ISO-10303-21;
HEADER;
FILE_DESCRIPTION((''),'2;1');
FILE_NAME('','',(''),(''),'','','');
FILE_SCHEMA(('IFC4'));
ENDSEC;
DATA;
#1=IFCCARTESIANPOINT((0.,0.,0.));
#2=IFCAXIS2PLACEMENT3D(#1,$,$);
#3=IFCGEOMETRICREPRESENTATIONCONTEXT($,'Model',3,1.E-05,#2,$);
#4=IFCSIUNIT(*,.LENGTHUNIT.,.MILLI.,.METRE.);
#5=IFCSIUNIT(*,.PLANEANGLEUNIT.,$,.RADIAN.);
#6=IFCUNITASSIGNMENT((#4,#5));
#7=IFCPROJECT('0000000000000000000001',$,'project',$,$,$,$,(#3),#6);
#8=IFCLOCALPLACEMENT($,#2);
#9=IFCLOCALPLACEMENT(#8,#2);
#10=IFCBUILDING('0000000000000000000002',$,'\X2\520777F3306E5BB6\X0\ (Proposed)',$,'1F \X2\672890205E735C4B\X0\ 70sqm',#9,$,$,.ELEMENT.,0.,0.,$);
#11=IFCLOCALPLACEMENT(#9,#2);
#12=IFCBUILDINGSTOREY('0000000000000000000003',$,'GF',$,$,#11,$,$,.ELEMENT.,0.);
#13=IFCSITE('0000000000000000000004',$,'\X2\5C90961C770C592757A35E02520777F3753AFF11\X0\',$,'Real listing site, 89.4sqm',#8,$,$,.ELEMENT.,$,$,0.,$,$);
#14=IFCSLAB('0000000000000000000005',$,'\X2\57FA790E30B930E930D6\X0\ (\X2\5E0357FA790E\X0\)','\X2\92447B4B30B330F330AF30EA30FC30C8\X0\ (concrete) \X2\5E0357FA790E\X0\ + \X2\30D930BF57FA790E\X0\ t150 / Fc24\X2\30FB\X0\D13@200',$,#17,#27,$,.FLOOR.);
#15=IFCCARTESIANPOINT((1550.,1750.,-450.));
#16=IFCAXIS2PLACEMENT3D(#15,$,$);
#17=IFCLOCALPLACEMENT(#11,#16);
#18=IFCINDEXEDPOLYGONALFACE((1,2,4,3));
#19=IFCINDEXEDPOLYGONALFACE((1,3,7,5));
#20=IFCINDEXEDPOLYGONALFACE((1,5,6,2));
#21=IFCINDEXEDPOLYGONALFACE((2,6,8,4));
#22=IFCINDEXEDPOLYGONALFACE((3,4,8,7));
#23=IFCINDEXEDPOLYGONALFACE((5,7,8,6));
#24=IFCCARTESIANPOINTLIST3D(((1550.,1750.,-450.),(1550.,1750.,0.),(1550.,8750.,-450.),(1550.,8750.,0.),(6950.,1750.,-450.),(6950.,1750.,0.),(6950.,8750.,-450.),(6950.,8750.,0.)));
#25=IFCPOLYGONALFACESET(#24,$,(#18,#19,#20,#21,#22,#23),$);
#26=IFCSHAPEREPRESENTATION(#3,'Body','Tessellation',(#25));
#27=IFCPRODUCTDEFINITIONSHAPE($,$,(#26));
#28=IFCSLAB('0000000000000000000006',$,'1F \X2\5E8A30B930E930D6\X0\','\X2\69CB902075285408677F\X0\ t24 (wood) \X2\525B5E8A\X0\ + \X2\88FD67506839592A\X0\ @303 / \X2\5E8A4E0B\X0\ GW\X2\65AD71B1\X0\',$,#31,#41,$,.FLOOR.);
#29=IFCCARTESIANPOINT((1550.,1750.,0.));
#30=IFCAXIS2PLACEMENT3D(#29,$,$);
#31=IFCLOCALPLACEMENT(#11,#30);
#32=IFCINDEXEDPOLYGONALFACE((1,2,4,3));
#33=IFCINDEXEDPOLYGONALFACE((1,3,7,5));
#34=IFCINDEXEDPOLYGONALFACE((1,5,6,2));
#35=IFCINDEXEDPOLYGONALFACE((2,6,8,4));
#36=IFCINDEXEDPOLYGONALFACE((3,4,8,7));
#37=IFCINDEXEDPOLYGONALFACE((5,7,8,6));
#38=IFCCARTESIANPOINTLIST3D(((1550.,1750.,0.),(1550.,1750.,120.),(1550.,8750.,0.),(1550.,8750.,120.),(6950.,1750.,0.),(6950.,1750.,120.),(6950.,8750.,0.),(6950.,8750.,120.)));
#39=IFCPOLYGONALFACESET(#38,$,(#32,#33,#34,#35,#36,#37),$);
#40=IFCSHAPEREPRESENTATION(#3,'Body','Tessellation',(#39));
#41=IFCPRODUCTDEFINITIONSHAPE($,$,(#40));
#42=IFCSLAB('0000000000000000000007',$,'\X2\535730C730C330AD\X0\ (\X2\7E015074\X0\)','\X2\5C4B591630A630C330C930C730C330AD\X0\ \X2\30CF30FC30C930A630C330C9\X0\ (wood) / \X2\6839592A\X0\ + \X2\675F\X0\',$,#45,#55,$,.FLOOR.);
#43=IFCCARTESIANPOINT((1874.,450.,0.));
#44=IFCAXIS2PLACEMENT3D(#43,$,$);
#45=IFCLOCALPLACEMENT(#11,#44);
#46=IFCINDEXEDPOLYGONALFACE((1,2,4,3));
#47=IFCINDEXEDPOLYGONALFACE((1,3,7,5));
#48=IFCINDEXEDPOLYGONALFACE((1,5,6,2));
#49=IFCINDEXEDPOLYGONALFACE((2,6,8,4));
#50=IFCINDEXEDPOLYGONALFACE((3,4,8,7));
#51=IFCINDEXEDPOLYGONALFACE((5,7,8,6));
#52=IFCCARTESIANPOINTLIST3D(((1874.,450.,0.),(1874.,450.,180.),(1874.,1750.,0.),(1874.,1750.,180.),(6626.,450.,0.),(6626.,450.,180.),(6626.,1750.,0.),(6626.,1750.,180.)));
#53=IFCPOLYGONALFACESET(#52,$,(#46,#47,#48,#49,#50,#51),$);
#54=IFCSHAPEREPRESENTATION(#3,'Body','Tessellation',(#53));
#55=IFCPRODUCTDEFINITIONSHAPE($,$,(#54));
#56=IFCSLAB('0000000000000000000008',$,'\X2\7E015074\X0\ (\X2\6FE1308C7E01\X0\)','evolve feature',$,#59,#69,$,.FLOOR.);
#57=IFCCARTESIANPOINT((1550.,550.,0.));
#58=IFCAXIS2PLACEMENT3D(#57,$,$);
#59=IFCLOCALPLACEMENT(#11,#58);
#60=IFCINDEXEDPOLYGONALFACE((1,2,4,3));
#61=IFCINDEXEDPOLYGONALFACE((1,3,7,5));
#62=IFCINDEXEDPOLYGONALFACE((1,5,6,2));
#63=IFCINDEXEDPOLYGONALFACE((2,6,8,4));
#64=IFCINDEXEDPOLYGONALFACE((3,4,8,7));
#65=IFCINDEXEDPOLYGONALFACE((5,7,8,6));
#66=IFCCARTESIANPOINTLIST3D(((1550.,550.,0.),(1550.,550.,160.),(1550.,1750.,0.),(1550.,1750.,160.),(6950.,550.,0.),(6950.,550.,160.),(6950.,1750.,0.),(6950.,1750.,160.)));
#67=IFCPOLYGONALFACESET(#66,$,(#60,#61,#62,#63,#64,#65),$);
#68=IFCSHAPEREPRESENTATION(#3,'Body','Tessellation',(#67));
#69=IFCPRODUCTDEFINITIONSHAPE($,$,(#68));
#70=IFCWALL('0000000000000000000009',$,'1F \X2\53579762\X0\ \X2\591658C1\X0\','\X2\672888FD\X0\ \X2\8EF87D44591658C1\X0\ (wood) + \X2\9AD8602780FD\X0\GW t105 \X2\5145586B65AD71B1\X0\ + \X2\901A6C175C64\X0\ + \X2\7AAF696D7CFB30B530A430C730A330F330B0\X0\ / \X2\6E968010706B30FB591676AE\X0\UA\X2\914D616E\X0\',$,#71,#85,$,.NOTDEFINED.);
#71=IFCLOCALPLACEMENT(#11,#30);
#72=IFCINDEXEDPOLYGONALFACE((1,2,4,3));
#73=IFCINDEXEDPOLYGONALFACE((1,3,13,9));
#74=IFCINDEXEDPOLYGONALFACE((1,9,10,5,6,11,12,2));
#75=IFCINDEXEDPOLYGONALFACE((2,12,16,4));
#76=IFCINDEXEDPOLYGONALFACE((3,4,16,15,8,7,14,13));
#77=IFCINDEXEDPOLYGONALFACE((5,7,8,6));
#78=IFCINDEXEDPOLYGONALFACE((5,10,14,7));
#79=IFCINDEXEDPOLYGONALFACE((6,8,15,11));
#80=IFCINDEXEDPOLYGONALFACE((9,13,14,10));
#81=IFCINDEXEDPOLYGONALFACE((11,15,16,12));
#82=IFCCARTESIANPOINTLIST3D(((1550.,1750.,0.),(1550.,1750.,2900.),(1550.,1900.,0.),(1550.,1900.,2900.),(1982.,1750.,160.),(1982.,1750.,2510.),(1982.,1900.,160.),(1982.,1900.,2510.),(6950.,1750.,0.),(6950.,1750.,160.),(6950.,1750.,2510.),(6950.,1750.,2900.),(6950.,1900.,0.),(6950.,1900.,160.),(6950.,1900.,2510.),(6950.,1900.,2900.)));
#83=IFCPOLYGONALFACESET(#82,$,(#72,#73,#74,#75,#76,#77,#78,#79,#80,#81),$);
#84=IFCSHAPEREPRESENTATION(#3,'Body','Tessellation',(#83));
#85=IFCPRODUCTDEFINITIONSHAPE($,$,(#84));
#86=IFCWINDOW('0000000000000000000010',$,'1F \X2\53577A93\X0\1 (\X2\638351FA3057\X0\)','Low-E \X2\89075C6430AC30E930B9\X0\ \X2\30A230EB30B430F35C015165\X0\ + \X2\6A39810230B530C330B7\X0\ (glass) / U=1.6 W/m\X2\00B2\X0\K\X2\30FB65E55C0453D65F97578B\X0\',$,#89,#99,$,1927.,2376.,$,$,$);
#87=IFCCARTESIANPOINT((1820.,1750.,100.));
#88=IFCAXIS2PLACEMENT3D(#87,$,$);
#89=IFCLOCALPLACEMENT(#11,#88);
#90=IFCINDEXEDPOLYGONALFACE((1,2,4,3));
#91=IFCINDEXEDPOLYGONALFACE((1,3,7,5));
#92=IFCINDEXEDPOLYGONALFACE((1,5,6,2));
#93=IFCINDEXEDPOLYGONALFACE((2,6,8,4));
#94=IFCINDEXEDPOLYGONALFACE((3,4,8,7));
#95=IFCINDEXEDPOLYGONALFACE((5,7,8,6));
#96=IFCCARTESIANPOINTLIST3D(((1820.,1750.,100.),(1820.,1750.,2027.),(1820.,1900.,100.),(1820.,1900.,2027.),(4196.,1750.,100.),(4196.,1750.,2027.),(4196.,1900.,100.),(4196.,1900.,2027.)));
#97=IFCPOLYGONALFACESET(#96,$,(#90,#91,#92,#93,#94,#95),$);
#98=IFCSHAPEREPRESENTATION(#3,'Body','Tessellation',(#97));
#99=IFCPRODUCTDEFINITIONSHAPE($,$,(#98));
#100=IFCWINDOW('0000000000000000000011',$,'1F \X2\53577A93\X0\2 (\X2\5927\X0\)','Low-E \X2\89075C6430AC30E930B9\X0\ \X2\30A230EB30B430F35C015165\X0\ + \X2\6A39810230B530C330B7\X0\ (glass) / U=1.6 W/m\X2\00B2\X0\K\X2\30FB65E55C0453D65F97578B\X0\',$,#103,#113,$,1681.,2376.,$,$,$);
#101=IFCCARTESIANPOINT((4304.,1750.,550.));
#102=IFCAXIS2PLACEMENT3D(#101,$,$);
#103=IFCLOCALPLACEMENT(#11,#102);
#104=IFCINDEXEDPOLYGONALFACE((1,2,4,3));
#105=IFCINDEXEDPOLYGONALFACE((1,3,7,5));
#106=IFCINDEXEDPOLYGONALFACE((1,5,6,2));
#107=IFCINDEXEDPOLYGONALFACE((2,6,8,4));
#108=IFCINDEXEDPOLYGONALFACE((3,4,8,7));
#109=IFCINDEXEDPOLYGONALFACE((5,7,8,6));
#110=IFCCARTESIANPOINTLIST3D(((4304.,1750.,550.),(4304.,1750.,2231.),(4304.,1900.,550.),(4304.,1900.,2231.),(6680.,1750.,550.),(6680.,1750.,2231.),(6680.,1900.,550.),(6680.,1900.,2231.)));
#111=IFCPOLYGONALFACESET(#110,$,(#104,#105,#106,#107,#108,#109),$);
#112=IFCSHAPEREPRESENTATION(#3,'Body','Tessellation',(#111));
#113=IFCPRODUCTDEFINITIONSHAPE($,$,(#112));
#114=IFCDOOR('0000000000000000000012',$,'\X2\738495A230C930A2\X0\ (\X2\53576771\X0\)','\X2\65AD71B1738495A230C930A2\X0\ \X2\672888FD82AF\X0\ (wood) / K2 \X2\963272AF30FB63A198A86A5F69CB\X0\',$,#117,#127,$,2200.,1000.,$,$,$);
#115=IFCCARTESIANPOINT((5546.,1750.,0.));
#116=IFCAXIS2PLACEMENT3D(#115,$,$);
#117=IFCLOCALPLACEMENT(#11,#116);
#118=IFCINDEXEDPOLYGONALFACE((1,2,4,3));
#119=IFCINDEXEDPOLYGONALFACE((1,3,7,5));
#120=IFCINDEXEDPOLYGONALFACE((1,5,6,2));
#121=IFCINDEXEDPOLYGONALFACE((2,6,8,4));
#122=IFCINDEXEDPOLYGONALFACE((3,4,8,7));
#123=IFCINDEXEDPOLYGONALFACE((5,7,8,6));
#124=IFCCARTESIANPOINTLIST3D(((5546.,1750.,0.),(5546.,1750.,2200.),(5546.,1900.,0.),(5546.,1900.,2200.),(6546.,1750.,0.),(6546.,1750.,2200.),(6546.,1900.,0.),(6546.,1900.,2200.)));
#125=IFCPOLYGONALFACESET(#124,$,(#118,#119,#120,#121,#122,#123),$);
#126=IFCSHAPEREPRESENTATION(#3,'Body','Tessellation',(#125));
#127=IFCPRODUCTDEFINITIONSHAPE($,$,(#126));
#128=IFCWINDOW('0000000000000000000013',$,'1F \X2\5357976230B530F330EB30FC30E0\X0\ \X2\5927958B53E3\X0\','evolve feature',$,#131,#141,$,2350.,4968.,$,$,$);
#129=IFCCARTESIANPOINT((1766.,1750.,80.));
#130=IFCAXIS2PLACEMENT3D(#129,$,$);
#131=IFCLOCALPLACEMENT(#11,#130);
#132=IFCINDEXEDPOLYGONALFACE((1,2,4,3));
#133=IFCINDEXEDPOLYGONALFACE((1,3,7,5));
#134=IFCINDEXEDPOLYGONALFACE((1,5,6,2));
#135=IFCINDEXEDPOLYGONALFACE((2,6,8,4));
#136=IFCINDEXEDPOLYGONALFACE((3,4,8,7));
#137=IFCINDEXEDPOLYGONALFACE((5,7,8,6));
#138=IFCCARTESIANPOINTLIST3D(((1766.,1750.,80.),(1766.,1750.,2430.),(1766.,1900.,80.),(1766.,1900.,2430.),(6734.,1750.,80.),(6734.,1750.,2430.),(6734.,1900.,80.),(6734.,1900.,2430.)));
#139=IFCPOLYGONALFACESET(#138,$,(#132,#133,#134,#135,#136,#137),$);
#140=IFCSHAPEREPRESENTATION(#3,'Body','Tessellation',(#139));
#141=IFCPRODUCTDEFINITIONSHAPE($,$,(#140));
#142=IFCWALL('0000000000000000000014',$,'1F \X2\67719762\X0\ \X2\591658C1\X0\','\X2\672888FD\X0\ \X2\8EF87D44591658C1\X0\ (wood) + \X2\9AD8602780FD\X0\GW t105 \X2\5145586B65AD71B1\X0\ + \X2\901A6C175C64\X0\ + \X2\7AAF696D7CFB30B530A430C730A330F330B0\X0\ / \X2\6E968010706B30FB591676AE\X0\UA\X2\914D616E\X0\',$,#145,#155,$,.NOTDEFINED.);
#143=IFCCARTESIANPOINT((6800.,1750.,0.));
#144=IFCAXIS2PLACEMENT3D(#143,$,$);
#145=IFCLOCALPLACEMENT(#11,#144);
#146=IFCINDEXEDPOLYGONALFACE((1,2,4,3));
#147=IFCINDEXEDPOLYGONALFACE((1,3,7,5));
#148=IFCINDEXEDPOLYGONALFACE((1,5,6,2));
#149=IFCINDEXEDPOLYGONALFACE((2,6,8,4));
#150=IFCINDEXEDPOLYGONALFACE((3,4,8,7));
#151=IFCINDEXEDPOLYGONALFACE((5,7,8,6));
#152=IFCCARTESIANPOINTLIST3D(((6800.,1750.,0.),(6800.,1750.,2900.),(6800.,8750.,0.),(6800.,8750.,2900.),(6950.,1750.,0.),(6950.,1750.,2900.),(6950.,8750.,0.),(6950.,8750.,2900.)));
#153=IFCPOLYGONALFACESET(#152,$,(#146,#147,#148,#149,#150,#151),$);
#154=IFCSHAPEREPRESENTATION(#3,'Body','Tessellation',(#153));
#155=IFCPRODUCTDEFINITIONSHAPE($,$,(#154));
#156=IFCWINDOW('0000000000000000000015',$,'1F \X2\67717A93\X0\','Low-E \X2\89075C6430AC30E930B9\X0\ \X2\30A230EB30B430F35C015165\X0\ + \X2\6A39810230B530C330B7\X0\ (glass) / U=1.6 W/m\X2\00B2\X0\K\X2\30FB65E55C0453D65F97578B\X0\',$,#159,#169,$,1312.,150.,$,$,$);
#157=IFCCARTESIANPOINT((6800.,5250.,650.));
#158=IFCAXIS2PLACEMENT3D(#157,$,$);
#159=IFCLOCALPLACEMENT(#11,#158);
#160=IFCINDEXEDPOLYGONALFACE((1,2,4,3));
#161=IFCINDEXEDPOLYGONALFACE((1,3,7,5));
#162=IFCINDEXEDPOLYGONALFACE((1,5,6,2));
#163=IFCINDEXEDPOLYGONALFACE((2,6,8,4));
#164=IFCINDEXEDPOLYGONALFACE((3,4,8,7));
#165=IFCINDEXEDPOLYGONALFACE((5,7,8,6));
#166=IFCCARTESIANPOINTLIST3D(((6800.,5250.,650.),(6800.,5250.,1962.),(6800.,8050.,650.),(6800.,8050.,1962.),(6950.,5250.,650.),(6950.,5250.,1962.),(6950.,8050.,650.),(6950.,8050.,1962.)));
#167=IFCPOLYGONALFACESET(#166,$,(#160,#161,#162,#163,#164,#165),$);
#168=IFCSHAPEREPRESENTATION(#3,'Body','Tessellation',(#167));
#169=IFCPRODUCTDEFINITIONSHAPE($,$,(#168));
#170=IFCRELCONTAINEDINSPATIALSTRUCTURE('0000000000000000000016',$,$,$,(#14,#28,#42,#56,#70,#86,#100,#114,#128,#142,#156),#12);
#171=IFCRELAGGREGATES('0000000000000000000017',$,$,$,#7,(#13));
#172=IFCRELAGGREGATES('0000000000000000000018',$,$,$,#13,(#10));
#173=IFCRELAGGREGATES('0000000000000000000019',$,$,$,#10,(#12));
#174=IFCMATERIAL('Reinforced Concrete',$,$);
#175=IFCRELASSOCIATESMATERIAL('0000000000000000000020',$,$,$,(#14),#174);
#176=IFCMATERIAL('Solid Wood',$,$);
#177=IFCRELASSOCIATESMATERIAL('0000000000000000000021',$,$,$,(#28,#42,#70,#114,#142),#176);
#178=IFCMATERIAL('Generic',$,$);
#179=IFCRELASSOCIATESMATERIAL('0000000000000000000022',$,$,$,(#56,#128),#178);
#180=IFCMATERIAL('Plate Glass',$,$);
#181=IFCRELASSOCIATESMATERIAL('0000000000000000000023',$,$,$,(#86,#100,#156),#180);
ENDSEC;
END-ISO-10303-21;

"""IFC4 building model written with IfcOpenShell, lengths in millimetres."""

from ifc_helpers import new_model, si_unit, frame, frame_2d, origin, place, context, project, spatial, rectangle, extrude, material, element, fill, save


model = new_model("IFC4")

# Units and contexts
model_context = context("Model", 3, precision=1e-05, world=origin())
ifc_project = project(units=[si_unit("LENGTHUNIT", "METRE", prefix="MILLI"), si_unit("PLANEANGLEUNIT", "RADIAN")], contexts=[model_context])

# Site, building, storey
site_placement = place(None, origin())
site = spatial("IfcSite", under=ifc_project, at=site_placement, Name="岐阜県大垣市切石町１", ObjectType="Real listing site, 89.4sqm", CompositionType="ELEMENT", RefElevation=0.0)
building_placement = place(site_placement, origin())
building = spatial("IfcBuilding", under=site, at=building_placement, Name="切石の家 (Proposed)", ObjectType="1F 木造平屋 70sqm", CompositionType="ELEMENT", ElevationOfRefHeight=0.0, ElevationOfTerrain=0.0)
storey_placement = place(building_placement, origin())
storey = spatial("IfcBuildingStorey", under=building, at=storey_placement, Name="GF", CompositionType="ELEMENT", Elevation=0.0)

# Slabs
ifc_material_1 = material(Name="Reinforced Concrete")
slab_1_placement = place(storey_placement, frame((1550.0, 1750.0, -450.0)))
element("IfcSlab", 1, at=slab_1_placement, inside=storey, material=ifc_material_1, Name="基礎スラブ (布基礎)", Description="鉄筋コンクリート (concrete) 布基礎 + ベタ基礎 t150 / Fc24・D13@200", PredefinedType="FLOOR", context=model_context, shape_type="SweptSolid", body=[
    extrude(rectangle(XDim=5400.0, YDim=7000.0, at=frame_2d((2700.0, 3500.0))), frame((1550.0, 1750.0, -450.0)), (0.0, 0.0, 1.0), 450.0),
])
ifc_material_2 = material(Name="Solid Wood")
slab_2_placement = place(storey_placement, frame((1550.0, 1750.0, 0.0)))
element("IfcSlab", 2, at=slab_2_placement, inside=storey, material=ifc_material_2, Name="1F 床スラブ", Description="構造用合板 t24 (wood) 剛床 + 製材根太 @303 / 床下 GW断熱", PredefinedType="FLOOR", context=model_context, shape_type="SweptSolid", body=[
    extrude(rectangle(XDim=5400.0, YDim=7000.0, at=frame_2d((2700.0, 3500.0))), frame((1550.0, 1750.0, 0.0)), (0.0, 0.0, 1.0), 120.0),
])
slab_3_placement = place(storey_placement, frame((1874.0, 450.0, 0.0)))
element("IfcSlab", 3, at=slab_3_placement, inside=storey, material=ifc_material_2, Name="南デッキ (縁側)", Description="屋外ウッドデッキ ハードウッド (wood) / 根太 + 束", PredefinedType="FLOOR", context=model_context, shape_type="SweptSolid", body=[
    extrude(rectangle(XDim=4752.0, YDim=1300.0, at=frame_2d((2376.0, 650.0))), frame((1874.0, 450.0, 0.0)), (0.0, 0.0, 1.0), 180.0),
])
ifc_material_3 = material(Name="Generic")
slab_4_placement = place(storey_placement, frame((1550.0, 550.0, 0.0)))
element("IfcSlab", 4, at=slab_4_placement, inside=storey, material=ifc_material_3, Name="縁側 (濡れ縁)", Description="evolve feature", PredefinedType="FLOOR", context=model_context, shape_type="SweptSolid", body=[
    extrude(rectangle(XDim=5400.0, YDim=1200.0, at=frame_2d((2700.0, 600.0))), frame((1550.0, 550.0, 0.0)), (0.0, 0.0, 1.0), 160.0),
])

# Wall, openings, windows, door
wall_1_placement = place(storey_placement, frame((1550.0, 1750.0, 0.0)))
wall_1 = element("IfcWall", 5, at=wall_1_placement, inside=storey, material=ifc_material_2, Name="1F 南面 外壁", Description="木製 軸組外壁 (wood) + 高性能GW t105 充填断熱 + 通気層 + 窯業系サイディング / 準耐火・外皮UA配慮", PredefinedType="NOTDEFINED", context=model_context, shape_type="SweptSolid", body=[
    extrude(rectangle(XDim=5400.0, YDim=150.0, at=frame_2d((2700.0, 75.0))), frame((1550.0, 1750.0, 0.0)), (0.0, 0.0, 1.0), 2900.0),
])
opening_1_placement = place(storey_placement, frame((1820.0, 1750.0, 100.0)))
opening_1 = element("IfcOpeningElement", 6, at=opening_1_placement, cuts=wall_1, PredefinedType="NOTDEFINED", context=model_context, shape_type="SweptSolid", body=[
    extrude(rectangle(XDim=2376.0, YDim=150.0, at=frame_2d((1188.0, 75.0))), frame((1820.0, 1750.0, 100.0)), (0.0, 0.0, 1.0), 1927.0),
])
opening_2_placement = place(storey_placement, frame((4304.0, 1750.0, 550.0)))
opening_2 = element("IfcOpeningElement", 7, at=opening_2_placement, cuts=wall_1, PredefinedType="NOTDEFINED", context=model_context, shape_type="SweptSolid", body=[
    extrude(rectangle(XDim=2376.0, YDim=150.0, at=frame_2d((1188.0, 75.0))), frame((4304.0, 1750.0, 550.0)), (0.0, 0.0, 1.0), 1681.0),
])
opening_3_placement = place(storey_placement, frame((5546.0, 1750.0, 0.0)))
opening_3 = element("IfcOpeningElement", 8, at=opening_3_placement, cuts=wall_1, PredefinedType="NOTDEFINED", context=model_context, shape_type="SweptSolid", body=[
    extrude(rectangle(XDim=1000.0, YDim=150.0, at=frame_2d((500.0, 75.0))), frame((5546.0, 1750.0, 0.0)), (0.0, 0.0, 1.0), 2200.0),
])
opening_4_placement = place(storey_placement, frame((1766.0, 1750.0, 80.0)))
opening_4 = element("IfcOpeningElement", 9, at=opening_4_placement, cuts=wall_1, PredefinedType="NOTDEFINED", context=model_context, shape_type="SweptSolid", body=[
    extrude(rectangle(XDim=4968.0, YDim=150.0, at=frame_2d((2484.0, 75.0))), frame((1766.0, 1750.0, 80.0)), (0.0, 0.0, 1.0), 2350.0),
])
ifc_material_4 = material(Name="Plate Glass")
window_1_placement = place(storey_placement, frame((1820.0, 1750.0, 100.0)))
window_1 = element("IfcWindow", 10, at=window_1_placement, inside=storey, material=ifc_material_4, Name="1F 南窓1 (掃出し)", Description="Low-E 複層ガラス アルゴン封入 + 樹脂サッシ (glass) / U=1.6 W/m²K・日射取得型", OverallHeight=1927.0, OverallWidth=2376.0, context=model_context, shape_type="SweptSolid", body=[
    extrude(rectangle(XDim=2376.0, YDim=150.0, at=frame_2d((1188.0, 75.0))), frame((1820.0, 1750.0, 100.0)), (0.0, 0.0, 1.0), 1927.0),
])
fill(opening_1, window_1)
window_2_placement = place(storey_placement, frame((4304.0, 1750.0, 550.0)))
window_2 = element("IfcWindow", 11, at=window_2_placement, inside=storey, material=ifc_material_4, Name="1F 南窓2 (大)", Description="Low-E 複層ガラス アルゴン封入 + 樹脂サッシ (glass) / U=1.6 W/m²K・日射取得型", OverallHeight=1681.0, OverallWidth=2376.0, context=model_context, shape_type="SweptSolid", body=[
    extrude(rectangle(XDim=2376.0, YDim=150.0, at=frame_2d((1188.0, 75.0))), frame((4304.0, 1750.0, 550.0)), (0.0, 0.0, 1.0), 1681.0),
])
fill(opening_2, window_2)
door_placement = place(storey_placement, frame((5546.0, 1750.0, 0.0)))
door = element("IfcDoor", 12, at=door_placement, inside=storey, material=ifc_material_2, Name="玄関ドア (南東)", Description="断熱玄関ドア 木製芯 (wood) / K2 防犯・採風機構", OverallHeight=2200.0, OverallWidth=1000.0, context=model_context, shape_type="SweptSolid", body=[
    extrude(rectangle(XDim=1000.0, YDim=150.0, at=frame_2d((500.0, 75.0))), frame((5546.0, 1750.0, 0.0)), (0.0, 0.0, 1.0), 2200.0),
])
fill(opening_3, door)
window_3_placement = place(storey_placement, frame((1766.0, 1750.0, 80.0)))
window_3 = element("IfcWindow", 13, at=window_3_placement, inside=storey, material=ifc_material_3, Name="1F 南面サンルーム 大開口", Description="evolve feature", OverallHeight=2350.0, OverallWidth=4968.0, context=model_context, shape_type="SweptSolid", body=[
    extrude(rectangle(XDim=4968.0, YDim=150.0, at=frame_2d((2484.0, 75.0))), frame((1766.0, 1750.0, 80.0)), (0.0, 0.0, 1.0), 2350.0),
])
fill(opening_4, window_3)

# Wall, opening, window
wall_2_placement = place(storey_placement, frame((6800.0, 1750.0, 0.0)))
wall_2 = element("IfcWall", 14, at=wall_2_placement, inside=storey, material=ifc_material_2, Name="1F 東面 外壁", Description="木製 軸組外壁 (wood) + 高性能GW t105 充填断熱 + 通気層 + 窯業系サイディング / 準耐火・外皮UA配慮", PredefinedType="NOTDEFINED", context=model_context, shape_type="SweptSolid", body=[
    extrude(rectangle(XDim=150.0, YDim=7000.0, at=frame_2d((75.0, 3500.0))), frame((6800.0, 1750.0, 0.0)), (0.0, 0.0, 1.0), 2900.0),
])
opening_5_placement = place(storey_placement, frame((6800.0, 5250.0, 650.0)))
opening_5 = element("IfcOpeningElement", 15, at=opening_5_placement, cuts=wall_2, PredefinedType="NOTDEFINED", context=model_context, shape_type="SweptSolid", body=[
    extrude(rectangle(XDim=150.0, YDim=2800.0, at=frame_2d((75.0, 1400.0))), frame((6800.0, 5250.0, 650.0)), (0.0, 0.0, 1.0), 1312.0),
])
window_4_placement = place(storey_placement, frame((6800.0, 5250.0, 650.0)))
window_4 = element("IfcWindow", 16, at=window_4_placement, inside=storey, material=ifc_material_4, Name="1F 東窓", Description="Low-E 複層ガラス アルゴン封入 + 樹脂サッシ (glass) / U=1.6 W/m²K・日射取得型", OverallHeight=1312.0, OverallWidth=150.0, context=model_context, shape_type="SweptSolid", body=[
    extrude(rectangle(XDim=150.0, YDim=2800.0, at=frame_2d((75.0, 1400.0))), frame((6800.0, 5250.0, 650.0)), (0.0, 0.0, 1.0), 1312.0),
])
fill(opening_5, window_4)

save(model, "model.ifc")
